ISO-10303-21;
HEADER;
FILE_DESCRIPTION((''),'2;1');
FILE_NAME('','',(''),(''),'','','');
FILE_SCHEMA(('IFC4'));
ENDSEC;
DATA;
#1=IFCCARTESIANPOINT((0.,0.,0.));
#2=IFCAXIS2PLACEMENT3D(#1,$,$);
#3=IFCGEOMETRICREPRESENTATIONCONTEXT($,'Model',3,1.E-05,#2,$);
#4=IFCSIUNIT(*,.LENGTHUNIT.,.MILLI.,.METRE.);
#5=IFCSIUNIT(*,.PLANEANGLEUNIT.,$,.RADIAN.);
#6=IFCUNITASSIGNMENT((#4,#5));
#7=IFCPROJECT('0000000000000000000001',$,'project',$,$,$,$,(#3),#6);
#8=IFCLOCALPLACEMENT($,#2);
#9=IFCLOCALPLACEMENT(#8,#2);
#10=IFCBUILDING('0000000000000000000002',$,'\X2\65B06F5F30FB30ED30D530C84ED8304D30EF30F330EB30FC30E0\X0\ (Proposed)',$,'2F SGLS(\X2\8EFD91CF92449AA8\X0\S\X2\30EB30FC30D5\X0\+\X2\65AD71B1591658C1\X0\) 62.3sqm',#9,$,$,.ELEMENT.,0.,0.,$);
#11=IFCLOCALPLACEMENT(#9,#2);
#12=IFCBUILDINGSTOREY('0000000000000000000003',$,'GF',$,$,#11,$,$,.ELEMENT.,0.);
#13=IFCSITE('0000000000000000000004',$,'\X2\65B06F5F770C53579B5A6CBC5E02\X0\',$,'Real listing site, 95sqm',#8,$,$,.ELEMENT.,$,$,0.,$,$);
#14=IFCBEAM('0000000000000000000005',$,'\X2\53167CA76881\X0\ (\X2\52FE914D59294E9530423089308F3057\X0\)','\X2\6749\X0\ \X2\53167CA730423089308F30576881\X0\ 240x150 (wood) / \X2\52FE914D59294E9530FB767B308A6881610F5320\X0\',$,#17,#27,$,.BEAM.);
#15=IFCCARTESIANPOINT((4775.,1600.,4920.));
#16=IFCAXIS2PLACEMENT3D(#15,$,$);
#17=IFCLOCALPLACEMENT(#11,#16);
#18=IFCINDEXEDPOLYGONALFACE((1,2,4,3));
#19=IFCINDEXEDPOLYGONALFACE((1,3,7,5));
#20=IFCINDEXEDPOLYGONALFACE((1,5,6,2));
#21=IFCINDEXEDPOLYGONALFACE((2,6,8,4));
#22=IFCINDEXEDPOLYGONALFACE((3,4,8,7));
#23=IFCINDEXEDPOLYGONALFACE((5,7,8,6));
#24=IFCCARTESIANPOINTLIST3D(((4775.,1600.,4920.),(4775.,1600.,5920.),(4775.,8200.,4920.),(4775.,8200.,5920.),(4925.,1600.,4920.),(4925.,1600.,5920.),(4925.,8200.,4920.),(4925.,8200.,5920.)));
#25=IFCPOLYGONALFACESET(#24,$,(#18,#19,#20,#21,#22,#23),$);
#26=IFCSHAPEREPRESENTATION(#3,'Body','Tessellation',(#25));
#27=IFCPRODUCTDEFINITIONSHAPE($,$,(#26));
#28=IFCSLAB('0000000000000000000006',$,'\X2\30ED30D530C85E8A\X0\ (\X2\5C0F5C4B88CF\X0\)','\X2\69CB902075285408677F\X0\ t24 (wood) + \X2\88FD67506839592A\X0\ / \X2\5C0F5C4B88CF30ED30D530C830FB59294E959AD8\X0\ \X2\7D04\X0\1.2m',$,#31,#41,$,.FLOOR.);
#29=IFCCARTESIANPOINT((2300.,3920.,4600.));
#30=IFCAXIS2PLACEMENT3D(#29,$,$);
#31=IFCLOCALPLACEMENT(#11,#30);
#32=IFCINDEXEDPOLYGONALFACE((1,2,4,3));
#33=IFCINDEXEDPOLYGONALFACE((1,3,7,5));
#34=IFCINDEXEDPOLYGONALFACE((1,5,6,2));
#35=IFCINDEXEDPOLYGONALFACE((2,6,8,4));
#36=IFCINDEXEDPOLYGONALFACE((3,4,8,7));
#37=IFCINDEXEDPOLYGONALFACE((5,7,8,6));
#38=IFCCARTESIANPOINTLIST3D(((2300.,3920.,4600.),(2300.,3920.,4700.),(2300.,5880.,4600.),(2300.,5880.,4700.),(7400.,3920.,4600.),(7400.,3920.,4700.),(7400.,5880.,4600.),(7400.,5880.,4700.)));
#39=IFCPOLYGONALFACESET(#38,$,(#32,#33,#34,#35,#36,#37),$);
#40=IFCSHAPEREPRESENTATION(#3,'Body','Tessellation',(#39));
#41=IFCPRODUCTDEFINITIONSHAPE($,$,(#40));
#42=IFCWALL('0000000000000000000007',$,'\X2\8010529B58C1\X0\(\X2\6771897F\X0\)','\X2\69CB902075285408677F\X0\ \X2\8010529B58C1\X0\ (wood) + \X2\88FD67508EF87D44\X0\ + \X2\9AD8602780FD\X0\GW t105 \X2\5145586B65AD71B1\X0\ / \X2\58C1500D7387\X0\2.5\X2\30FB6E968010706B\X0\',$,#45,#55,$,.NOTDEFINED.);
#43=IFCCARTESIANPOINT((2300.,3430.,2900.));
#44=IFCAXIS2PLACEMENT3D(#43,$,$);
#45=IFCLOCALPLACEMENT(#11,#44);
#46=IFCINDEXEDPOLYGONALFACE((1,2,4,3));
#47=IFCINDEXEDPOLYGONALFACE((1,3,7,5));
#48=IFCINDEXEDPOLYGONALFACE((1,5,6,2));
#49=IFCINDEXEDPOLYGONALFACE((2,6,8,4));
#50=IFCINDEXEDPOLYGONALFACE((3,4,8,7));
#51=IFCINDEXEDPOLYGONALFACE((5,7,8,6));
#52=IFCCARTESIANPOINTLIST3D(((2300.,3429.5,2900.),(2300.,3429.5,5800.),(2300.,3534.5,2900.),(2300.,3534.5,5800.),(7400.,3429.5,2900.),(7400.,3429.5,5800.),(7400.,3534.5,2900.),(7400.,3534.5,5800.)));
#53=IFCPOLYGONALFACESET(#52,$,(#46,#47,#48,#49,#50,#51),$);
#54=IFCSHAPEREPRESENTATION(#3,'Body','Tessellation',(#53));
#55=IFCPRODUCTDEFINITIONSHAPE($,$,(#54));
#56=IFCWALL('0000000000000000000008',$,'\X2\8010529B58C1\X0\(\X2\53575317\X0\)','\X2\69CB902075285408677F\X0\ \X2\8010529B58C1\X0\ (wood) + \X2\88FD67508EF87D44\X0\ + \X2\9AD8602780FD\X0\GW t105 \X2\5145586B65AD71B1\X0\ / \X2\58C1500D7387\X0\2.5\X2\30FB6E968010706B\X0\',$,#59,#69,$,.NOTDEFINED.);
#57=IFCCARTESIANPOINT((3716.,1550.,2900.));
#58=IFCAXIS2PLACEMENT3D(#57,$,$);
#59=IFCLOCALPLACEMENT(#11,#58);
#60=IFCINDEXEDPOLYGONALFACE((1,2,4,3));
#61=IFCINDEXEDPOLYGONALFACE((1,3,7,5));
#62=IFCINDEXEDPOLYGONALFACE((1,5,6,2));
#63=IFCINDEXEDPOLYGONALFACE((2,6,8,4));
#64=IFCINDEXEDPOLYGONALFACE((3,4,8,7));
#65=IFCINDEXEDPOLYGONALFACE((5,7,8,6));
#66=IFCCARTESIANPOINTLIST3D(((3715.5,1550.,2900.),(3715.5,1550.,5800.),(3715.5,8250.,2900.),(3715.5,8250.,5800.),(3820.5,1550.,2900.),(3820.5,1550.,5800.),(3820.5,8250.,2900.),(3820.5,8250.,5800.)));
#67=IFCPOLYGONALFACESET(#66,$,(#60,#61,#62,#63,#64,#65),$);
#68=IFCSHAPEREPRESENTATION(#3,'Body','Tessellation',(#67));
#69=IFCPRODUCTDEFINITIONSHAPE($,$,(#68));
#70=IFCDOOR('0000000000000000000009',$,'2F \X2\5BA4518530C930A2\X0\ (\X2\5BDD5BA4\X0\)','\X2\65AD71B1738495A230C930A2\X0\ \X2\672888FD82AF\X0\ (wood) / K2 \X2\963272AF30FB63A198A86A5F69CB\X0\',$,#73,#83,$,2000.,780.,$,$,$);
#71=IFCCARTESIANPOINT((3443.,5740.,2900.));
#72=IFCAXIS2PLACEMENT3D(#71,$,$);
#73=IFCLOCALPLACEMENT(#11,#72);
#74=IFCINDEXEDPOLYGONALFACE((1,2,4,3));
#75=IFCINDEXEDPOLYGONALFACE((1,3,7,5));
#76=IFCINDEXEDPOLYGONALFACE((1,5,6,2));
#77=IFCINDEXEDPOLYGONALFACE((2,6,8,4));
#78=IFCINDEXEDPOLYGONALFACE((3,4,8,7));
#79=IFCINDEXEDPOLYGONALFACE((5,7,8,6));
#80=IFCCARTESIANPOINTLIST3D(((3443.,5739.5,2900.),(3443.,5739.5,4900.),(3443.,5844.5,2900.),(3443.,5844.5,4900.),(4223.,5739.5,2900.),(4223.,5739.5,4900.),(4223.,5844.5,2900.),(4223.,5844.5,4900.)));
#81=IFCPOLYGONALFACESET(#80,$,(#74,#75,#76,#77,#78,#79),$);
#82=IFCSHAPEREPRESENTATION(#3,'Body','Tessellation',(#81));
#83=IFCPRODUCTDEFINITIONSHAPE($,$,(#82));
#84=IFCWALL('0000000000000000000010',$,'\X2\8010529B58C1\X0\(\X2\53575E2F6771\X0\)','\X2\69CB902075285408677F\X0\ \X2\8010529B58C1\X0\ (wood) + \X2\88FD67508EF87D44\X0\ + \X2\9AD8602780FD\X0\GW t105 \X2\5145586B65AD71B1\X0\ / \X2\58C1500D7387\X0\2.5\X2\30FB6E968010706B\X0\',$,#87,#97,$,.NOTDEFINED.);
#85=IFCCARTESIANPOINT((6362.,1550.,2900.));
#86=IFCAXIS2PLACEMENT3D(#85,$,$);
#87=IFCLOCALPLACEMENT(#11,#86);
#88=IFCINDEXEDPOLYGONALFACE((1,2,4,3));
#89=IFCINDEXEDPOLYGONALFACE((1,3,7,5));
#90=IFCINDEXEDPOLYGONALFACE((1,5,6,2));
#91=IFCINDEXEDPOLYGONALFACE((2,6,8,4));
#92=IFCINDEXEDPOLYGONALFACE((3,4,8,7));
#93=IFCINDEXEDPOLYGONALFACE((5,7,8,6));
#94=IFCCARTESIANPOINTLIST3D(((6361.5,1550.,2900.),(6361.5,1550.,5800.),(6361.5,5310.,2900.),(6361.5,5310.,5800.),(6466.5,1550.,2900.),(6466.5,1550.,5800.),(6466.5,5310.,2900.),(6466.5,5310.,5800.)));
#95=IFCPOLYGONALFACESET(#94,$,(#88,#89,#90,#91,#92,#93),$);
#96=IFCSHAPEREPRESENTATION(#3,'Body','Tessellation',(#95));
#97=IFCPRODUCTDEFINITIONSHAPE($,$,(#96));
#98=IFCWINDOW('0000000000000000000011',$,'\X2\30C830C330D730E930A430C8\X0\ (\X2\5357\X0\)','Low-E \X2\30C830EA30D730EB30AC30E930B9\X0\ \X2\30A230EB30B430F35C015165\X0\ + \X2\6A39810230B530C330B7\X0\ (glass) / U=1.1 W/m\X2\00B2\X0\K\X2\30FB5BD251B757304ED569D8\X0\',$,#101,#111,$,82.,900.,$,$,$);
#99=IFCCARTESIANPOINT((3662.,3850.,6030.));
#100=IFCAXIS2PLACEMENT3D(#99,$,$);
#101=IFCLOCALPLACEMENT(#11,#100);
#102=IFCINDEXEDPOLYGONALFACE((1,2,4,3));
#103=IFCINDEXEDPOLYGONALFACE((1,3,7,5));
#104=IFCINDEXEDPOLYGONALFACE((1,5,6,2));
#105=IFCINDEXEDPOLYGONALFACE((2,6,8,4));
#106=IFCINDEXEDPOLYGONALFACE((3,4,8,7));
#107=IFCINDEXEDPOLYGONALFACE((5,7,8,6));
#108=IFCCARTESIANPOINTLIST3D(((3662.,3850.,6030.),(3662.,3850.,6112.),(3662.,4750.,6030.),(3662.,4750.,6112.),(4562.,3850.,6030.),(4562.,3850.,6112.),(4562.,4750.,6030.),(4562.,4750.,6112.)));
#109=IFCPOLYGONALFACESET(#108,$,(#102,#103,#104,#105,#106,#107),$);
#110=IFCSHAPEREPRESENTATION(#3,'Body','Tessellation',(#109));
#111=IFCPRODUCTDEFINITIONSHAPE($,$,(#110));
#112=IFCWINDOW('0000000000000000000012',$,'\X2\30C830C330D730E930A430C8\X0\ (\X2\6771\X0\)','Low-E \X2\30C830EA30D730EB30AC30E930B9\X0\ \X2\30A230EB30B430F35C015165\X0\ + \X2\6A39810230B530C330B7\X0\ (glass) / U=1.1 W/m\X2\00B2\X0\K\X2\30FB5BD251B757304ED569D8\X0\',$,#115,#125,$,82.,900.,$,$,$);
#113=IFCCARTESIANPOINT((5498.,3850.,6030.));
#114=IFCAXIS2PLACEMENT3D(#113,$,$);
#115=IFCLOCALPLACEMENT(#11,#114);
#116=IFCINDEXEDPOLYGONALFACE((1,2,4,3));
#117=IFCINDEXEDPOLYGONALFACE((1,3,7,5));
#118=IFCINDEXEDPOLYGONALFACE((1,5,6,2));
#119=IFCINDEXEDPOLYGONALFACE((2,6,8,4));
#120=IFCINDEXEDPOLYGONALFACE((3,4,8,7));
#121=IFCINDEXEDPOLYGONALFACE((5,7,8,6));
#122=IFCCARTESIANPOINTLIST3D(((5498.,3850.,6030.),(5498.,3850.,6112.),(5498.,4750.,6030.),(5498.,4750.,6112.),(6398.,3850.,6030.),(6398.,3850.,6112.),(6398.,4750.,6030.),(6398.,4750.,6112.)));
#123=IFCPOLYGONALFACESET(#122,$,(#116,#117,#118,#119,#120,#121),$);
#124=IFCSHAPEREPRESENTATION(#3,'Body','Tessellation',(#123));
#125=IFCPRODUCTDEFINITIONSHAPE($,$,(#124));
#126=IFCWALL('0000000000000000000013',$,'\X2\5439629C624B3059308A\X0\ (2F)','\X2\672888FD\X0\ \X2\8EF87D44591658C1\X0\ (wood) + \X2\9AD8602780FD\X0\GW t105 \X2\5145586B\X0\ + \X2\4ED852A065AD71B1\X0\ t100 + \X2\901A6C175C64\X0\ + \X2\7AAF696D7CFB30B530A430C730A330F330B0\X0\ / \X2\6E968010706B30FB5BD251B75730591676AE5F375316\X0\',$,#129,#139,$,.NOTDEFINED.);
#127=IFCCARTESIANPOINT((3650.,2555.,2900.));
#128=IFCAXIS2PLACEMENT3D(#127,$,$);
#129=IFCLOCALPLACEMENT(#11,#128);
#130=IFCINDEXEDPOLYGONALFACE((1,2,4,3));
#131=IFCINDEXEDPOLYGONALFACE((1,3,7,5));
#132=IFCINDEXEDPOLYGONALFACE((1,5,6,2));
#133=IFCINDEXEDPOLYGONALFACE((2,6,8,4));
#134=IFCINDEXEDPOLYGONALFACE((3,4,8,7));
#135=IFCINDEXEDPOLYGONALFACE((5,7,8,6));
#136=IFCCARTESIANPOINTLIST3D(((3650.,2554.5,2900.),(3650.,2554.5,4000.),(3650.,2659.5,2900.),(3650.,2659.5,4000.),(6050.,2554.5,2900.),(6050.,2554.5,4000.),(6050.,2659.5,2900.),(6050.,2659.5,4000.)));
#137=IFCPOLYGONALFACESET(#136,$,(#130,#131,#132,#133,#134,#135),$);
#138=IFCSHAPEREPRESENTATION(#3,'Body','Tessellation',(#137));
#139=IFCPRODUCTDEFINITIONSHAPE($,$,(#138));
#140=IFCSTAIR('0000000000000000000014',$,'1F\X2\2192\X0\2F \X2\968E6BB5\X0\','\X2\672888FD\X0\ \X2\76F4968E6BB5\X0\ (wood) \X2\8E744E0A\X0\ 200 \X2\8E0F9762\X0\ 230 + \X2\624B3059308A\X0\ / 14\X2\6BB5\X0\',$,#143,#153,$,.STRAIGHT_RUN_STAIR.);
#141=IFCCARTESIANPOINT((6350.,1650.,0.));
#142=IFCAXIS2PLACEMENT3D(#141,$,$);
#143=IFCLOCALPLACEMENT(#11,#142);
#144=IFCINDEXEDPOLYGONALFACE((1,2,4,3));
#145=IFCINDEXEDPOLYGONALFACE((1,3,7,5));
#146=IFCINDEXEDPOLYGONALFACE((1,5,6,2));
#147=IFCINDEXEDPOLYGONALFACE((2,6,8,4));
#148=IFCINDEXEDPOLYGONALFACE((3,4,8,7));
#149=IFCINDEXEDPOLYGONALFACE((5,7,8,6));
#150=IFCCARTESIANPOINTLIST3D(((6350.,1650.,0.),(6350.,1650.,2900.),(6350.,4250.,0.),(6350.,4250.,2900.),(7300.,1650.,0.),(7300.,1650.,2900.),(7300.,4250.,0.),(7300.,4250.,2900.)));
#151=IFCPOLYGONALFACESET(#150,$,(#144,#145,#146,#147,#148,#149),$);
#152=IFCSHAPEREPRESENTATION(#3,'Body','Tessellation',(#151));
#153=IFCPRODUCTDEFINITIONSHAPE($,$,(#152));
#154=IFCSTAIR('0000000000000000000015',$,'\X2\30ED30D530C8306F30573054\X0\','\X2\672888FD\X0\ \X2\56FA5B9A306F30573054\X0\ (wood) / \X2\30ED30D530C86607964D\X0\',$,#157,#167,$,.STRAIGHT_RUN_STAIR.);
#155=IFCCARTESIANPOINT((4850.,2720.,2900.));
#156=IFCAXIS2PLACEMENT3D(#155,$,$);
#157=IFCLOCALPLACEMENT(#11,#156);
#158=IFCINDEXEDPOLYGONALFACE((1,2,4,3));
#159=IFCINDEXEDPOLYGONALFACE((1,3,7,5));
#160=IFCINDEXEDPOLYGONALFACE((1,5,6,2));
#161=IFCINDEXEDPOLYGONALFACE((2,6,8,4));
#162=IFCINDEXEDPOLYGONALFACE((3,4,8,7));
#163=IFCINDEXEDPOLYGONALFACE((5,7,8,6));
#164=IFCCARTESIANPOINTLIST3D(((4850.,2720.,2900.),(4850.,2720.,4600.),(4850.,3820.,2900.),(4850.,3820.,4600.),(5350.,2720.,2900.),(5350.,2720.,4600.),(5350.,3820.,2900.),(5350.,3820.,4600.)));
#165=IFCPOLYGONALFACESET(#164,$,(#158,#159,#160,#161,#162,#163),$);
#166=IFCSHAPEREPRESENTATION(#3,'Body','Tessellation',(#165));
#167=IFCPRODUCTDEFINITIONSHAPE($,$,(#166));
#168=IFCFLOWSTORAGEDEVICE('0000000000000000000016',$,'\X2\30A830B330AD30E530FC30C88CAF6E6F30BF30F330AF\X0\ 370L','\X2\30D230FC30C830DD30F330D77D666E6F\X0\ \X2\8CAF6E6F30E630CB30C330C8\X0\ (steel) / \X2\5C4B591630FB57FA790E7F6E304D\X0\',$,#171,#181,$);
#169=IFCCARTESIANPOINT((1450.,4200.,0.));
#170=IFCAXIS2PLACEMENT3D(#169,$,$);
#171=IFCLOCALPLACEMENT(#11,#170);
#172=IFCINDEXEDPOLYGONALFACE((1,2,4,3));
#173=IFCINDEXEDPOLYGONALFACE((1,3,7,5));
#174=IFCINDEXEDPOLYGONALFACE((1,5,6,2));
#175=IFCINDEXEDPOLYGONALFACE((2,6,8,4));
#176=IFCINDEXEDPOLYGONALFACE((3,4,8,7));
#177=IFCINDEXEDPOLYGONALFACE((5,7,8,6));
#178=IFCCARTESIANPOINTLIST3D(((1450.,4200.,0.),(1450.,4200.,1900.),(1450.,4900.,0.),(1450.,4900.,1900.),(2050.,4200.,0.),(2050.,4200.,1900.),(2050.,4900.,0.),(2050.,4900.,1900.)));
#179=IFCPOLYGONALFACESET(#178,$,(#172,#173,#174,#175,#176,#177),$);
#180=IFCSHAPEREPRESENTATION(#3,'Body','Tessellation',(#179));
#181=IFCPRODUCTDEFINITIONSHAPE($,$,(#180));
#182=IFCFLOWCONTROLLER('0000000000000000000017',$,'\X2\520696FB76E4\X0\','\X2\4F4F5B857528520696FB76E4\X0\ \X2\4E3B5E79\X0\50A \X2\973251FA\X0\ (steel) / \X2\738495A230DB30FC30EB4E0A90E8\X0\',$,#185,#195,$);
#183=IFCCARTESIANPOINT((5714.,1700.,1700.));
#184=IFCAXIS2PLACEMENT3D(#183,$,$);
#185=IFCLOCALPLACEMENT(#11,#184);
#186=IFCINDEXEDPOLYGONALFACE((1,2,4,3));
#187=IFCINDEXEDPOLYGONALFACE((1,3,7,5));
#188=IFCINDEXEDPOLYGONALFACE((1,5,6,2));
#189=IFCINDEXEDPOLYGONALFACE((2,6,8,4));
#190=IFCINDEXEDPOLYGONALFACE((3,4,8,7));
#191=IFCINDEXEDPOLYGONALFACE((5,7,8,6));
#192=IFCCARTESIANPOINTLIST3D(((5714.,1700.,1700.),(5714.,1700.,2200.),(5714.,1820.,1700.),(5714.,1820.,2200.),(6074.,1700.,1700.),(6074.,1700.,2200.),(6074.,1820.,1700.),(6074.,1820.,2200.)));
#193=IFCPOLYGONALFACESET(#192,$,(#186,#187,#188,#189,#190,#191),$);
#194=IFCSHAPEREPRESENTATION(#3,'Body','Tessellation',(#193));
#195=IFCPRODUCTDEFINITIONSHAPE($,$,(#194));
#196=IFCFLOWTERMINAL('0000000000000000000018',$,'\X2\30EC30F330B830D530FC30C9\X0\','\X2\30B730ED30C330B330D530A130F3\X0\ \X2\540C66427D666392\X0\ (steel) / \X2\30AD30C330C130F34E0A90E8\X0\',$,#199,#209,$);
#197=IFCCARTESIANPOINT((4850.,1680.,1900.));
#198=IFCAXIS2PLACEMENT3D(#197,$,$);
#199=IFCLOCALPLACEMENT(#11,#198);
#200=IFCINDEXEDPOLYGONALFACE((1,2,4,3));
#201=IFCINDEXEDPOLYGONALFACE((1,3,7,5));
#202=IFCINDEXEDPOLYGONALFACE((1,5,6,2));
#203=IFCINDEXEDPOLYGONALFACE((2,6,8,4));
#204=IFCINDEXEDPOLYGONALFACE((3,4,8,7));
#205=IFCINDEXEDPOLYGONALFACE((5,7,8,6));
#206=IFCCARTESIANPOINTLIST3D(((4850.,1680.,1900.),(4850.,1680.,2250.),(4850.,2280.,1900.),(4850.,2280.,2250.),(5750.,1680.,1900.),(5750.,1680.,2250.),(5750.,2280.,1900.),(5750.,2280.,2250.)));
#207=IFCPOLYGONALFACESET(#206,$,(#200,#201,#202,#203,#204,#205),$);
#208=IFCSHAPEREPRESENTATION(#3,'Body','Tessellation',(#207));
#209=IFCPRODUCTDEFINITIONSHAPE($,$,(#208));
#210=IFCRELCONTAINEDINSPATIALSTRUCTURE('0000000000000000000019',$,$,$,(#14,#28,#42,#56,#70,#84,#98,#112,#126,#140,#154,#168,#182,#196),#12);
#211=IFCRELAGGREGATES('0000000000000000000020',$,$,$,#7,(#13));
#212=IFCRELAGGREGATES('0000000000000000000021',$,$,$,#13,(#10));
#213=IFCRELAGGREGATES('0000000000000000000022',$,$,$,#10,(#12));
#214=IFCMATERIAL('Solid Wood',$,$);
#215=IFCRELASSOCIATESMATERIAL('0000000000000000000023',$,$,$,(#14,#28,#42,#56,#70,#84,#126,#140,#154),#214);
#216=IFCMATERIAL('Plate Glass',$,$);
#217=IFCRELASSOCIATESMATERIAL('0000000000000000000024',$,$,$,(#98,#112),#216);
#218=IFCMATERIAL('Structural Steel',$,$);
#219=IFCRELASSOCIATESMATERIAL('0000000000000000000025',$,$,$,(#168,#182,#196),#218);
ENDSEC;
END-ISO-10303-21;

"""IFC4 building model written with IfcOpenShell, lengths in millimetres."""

from ifc_helpers import new_model, si_unit, frame, frame_2d, origin, place, context, project, spatial, rectangle, extrude, material, element, fill, save


model = new_model("IFC4")

# Units and contexts
model_context = context("Model", 3, precision=1e-05, world=origin())
ifc_project = project(units=[si_unit("LENGTHUNIT", "METRE", prefix="MILLI"), si_unit("PLANEANGLEUNIT", "RADIAN")], contexts=[model_context])

# Site, building, storey
site_placement = place(None, origin())
site = spatial("IfcSite", under=ifc_project, at=site_placement, Name="新潟県南魚沼市", ObjectType="Real listing site, 95sqm", CompositionType="ELEMENT", RefElevation=0.0)
building_placement = place(site_placement, origin())
building = spatial("IfcBuilding", under=site, at=building_placement, Name="新潟・ロフト付きワンルーム (Proposed)", ObjectType="2F SGLS(軽量鉄骨Sルーフ+断熱外壁) 62.3sqm", CompositionType="ELEMENT", ElevationOfRefHeight=0.0, ElevationOfTerrain=0.0)
storey_placement = place(building_placement, origin())
storey = spatial("IfcBuildingStorey", under=building, at=storey_placement, Name="GF", CompositionType="ELEMENT", Elevation=0.0)

# Shared definitions
ifc_material_1 = material(Name="Solid Wood")

# Beam
beam_placement = place(storey_placement, frame((4775.0, 1600.0, 4920.0)))
element("IfcBeam", 1, at=beam_placement, inside=storey, material=ifc_material_1, Name="化粧梁 (勾配天井あらわし)", Description="杉 化粧あらわし梁 240x150 (wood) / 勾配天井・登り梁意匠", PredefinedType="BEAM", context=model_context, shape_type="SweptSolid", body=[
    extrude(rectangle(XDim=150.0, YDim=6600.0, at=frame_2d((75.0, 3300.0))), frame((4775.0, 1600.0, 4920.0)), (0.0, 0.0, 1.0), 1000.0),
])

# Slab
slab_placement = place(storey_placement, frame((2300.0, 3920.0, 4600.0)))
element("IfcSlab", 2, at=slab_placement, inside=storey, material=ifc_material_1, Name="ロフト床 (小屋裏)", Description="構造用合板 t24 (wood) + 製材根太 / 小屋裏ロフト・天井高 約1.2m", PredefinedType="FLOOR", context=model_context, shape_type="SweptSolid", body=[
    extrude(rectangle(XDim=5100.0, YDim=1960.0, at=frame_2d((2550.0, 980.0))), frame((2300.0, 3920.0, 4600.0)), (0.0, 0.0, 1.0), 100.0),
])

# Wall
wall_1_placement = place(storey_placement, frame((2300.0, 3430.0, 2900.0)))
element("IfcWall", 3, at=wall_1_placement, inside=storey, material=ifc_material_1, Name="耐力壁(東西)", Description="構造用合板 耐力壁 (wood) + 製材軸組 + 高性能GW t105 充填断熱 / 壁倍率2.5・準耐火", PredefinedType="NOTDEFINED", context=model_context, shape_type="SweptSolid", body=[
    extrude(rectangle(XDim=5100.0, YDim=105.0, at=frame_2d((2550.0, 52.0))), frame((2300.0, 3430.0, 2900.0)), (0.0, 0.0, 1.0), 2900.0),
])

# Wall, opening, door
wall_2_placement = place(storey_placement, frame((3716.0, 1550.0, 2900.0)))
wall_2 = element("IfcWall", 4, at=wall_2_placement, inside=storey, material=ifc_material_1, Name="耐力壁(南北)", Description="構造用合板 耐力壁 (wood) + 製材軸組 + 高性能GW t105 充填断熱 / 壁倍率2.5・準耐火", PredefinedType="NOTDEFINED", context=model_context, shape_type="SweptSolid", body=[
    extrude(rectangle(XDim=105.0, YDim=6700.0, at=frame_2d((52.0, 3350.0))), frame((3716.0, 1550.0, 2900.0)), (0.0, 0.0, 1.0), 2900.0),
])
opening_placement = place(storey_placement, frame((3443.0, 5740.0, 2900.0)))
opening = element("IfcOpeningElement", 5, at=opening_placement, cuts=wall_2, PredefinedType="NOTDEFINED", context=model_context, shape_type="SweptSolid", body=[
    extrude(rectangle(XDim=780.0, YDim=105.0, at=frame_2d((390.0, 52.0))), frame((3443.0, 5740.0, 2900.0)), (0.0, 0.0, 1.0), 2000.0),
])
door_placement = place(storey_placement, frame((3443.0, 5740.0, 2900.0)))
door = element("IfcDoor", 6, at=door_placement, inside=storey, material=ifc_material_1, Name="2F 室内ドア (寝室)", Description="断熱玄関ドア 木製芯 (wood) / K2 防犯・採風機構", OverallHeight=2000.0, OverallWidth=780.0, context=model_context, shape_type="SweptSolid", body=[
    extrude(rectangle(XDim=780.0, YDim=105.0, at=frame_2d((390.0, 52.0))), frame((3443.0, 5740.0, 2900.0)), (0.0, 0.0, 1.0), 2000.0),
])
fill(opening, door)

# Wall
wall_3_placement = place(storey_placement, frame((6362.0, 1550.0, 2900.0)))
element("IfcWall", 7, at=wall_3_placement, inside=storey, material=ifc_material_1, Name="耐力壁(南帯東)", Description="構造用合板 耐力壁 (wood) + 製材軸組 + 高性能GW t105 充填断熱 / 壁倍率2.5・準耐火", PredefinedType="NOTDEFINED", context=model_context, shape_type="SweptSolid", body=[
    extrude(rectangle(XDim=105.0, YDim=3760.0, at=frame_2d((52.0, 1880.0))), frame((6362.0, 1550.0, 2900.0)), (0.0, 0.0, 1.0), 2900.0),
])

# Windows
ifc_material_2 = material(Name="Plate Glass")
window_1_placement = place(storey_placement, frame((3662.0, 3850.0, 6030.0)))
element("IfcWindow", 8, at=window_1_placement, inside=storey, material=ifc_material_2, Name="トップライト (南)", Description="Low-E トリプルガラス アルゴン封入 + 樹脂サッシ (glass) / U=1.1 W/m²K・寒冷地仕様", OverallHeight=82.0, OverallWidth=900.0, context=model_context, shape_type="SweptSolid", body=[
    extrude(rectangle(XDim=900.0, YDim=900.0, at=frame_2d((450.0, 450.0))), frame((3662.0, 3850.0, 6030.0)), (0.0, 0.0, 1.0), 82.0),
])
window_2_placement = place(storey_placement, frame((5498.0, 3850.0, 6030.0)))
element("IfcWindow", 9, at=window_2_placement, inside=storey, material=ifc_material_2, Name="トップライト (東)", Description="Low-E トリプルガラス アルゴン封入 + 樹脂サッシ (glass) / U=1.1 W/m²K・寒冷地仕様", OverallHeight=82.0, OverallWidth=900.0, context=model_context, shape_type="SweptSolid", body=[
    extrude(rectangle(XDim=900.0, YDim=900.0, at=frame_2d((450.0, 450.0))), frame((5498.0, 3850.0, 6030.0)), (0.0, 0.0, 1.0), 82.0),
])

# Wall
wall_4_placement = place(storey_placement, frame((3650.0, 2555.0, 2900.0)))
element("IfcWall", 10, at=wall_4_placement, inside=storey, material=ifc_material_1, Name="吹抜手すり (2F)", Description="木製 軸組外壁 (wood) + 高性能GW t105 充填 + 付加断熱 t100 + 通気層 + 窯業系サイディング / 準耐火・寒冷地外皮強化", PredefinedType="NOTDEFINED", context=model_context, shape_type="SweptSolid", body=[
    extrude(rectangle(XDim=2400.0, YDim=105.0, at=frame_2d((1200.0, 52.0))), frame((3650.0, 2555.0, 2900.0)), (0.0, 0.0, 1.0), 1100.0),
])

# Stairs
stair_1_placement = place(storey_placement, frame((6350.0, 1650.0, 0.0)))
element("IfcStair", 11, at=stair_1_placement, inside=storey, material=ifc_material_1, Name="1F→2F 階段", Description="木製 直階段 (wood) 蹴上 200 踏面 230 + 手すり / 14段", PredefinedType="STRAIGHT_RUN_STAIR", context=model_context, shape_type="SweptSolid", body=[
    extrude(rectangle(XDim=950.0, YDim=2600.0, at=frame_2d((475.0, 1300.0))), frame((6350.0, 1650.0, 0.0)), (0.0, 0.0, 1.0), 2900.0),
])
stair_2_placement = place(storey_placement, frame((4850.0, 2720.0, 2900.0)))
element("IfcStair", 12, at=stair_2_placement, inside=storey, material=ifc_material_1, Name="ロフトはしご", Description="木製 固定はしご (wood) / ロフト昇降", PredefinedType="STRAIGHT_RUN_STAIR", context=model_context, shape_type="SweptSolid", body=[
    extrude(rectangle(XDim=500.0, YDim=1100.0, at=frame_2d((250.0, 550.0))), frame((4850.0, 2720.0, 2900.0)), (0.0, 0.0, 1.0), 1700.0),
])

# Flow storage device
ifc_material_3 = material(Name="Structural Steel")
flow_storage_device_placement = place(storey_placement, frame((1450.0, 4200.0, 0.0)))
element("IfcFlowStorageDevice", 13, at=flow_storage_device_placement, inside=storey, material=ifc_material_3, Name="エコキュート貯湯タンク 370L", Description="ヒートポンプ給湯 貯湯ユニット (steel) / 屋外・基礎置き", context=model_context, shape_type="SweptSolid", body=[
    extrude(rectangle(XDim=600.0, YDim=700.0, at=frame_2d((300.0, 350.0))), frame((1450.0, 4200.0, 0.0)), (0.0, 0.0, 1.0), 1900.0),
])

# Flow controller
flow_controller_placement = place(storey_placement, frame((5714.0, 1700.0, 1700.0)))
element("IfcFlowController", 14, at=flow_controller_placement, inside=storey, material=ifc_material_3, Name="分電盤", Description="住宅用分電盤 主幹50A 露出 (steel) / 玄関ホール上部", context=model_context, shape_type="SweptSolid", body=[
    extrude(rectangle(XDim=360.0, YDim=120.0, at=frame_2d((180.0, 60.0))), frame((5714.0, 1700.0, 1700.0)), (0.0, 0.0, 1.0), 500.0),
])

# Flow terminal
flow_terminal_1_placement = place(storey_placement, frame((4850.0, 1680.0, 1900.0)))
element("IfcFlowTerminal", 15, at=flow_terminal_1_placement, inside=storey, material=ifc_material_3, Name="レンジフード", Description="シロッコファン 同時給排 (steel) / キッチン上部", context=model_context, shape_type="SweptSolid", body=[
    extrude(rectangle(XDim=900.0, YDim=600.0, at=frame_2d((450.0, 300.0))), frame((4850.0, 1680.0, 1900.0)), (0.0, 0.0, 1.0), 350.0),
])

save(model, "model.ifc")
